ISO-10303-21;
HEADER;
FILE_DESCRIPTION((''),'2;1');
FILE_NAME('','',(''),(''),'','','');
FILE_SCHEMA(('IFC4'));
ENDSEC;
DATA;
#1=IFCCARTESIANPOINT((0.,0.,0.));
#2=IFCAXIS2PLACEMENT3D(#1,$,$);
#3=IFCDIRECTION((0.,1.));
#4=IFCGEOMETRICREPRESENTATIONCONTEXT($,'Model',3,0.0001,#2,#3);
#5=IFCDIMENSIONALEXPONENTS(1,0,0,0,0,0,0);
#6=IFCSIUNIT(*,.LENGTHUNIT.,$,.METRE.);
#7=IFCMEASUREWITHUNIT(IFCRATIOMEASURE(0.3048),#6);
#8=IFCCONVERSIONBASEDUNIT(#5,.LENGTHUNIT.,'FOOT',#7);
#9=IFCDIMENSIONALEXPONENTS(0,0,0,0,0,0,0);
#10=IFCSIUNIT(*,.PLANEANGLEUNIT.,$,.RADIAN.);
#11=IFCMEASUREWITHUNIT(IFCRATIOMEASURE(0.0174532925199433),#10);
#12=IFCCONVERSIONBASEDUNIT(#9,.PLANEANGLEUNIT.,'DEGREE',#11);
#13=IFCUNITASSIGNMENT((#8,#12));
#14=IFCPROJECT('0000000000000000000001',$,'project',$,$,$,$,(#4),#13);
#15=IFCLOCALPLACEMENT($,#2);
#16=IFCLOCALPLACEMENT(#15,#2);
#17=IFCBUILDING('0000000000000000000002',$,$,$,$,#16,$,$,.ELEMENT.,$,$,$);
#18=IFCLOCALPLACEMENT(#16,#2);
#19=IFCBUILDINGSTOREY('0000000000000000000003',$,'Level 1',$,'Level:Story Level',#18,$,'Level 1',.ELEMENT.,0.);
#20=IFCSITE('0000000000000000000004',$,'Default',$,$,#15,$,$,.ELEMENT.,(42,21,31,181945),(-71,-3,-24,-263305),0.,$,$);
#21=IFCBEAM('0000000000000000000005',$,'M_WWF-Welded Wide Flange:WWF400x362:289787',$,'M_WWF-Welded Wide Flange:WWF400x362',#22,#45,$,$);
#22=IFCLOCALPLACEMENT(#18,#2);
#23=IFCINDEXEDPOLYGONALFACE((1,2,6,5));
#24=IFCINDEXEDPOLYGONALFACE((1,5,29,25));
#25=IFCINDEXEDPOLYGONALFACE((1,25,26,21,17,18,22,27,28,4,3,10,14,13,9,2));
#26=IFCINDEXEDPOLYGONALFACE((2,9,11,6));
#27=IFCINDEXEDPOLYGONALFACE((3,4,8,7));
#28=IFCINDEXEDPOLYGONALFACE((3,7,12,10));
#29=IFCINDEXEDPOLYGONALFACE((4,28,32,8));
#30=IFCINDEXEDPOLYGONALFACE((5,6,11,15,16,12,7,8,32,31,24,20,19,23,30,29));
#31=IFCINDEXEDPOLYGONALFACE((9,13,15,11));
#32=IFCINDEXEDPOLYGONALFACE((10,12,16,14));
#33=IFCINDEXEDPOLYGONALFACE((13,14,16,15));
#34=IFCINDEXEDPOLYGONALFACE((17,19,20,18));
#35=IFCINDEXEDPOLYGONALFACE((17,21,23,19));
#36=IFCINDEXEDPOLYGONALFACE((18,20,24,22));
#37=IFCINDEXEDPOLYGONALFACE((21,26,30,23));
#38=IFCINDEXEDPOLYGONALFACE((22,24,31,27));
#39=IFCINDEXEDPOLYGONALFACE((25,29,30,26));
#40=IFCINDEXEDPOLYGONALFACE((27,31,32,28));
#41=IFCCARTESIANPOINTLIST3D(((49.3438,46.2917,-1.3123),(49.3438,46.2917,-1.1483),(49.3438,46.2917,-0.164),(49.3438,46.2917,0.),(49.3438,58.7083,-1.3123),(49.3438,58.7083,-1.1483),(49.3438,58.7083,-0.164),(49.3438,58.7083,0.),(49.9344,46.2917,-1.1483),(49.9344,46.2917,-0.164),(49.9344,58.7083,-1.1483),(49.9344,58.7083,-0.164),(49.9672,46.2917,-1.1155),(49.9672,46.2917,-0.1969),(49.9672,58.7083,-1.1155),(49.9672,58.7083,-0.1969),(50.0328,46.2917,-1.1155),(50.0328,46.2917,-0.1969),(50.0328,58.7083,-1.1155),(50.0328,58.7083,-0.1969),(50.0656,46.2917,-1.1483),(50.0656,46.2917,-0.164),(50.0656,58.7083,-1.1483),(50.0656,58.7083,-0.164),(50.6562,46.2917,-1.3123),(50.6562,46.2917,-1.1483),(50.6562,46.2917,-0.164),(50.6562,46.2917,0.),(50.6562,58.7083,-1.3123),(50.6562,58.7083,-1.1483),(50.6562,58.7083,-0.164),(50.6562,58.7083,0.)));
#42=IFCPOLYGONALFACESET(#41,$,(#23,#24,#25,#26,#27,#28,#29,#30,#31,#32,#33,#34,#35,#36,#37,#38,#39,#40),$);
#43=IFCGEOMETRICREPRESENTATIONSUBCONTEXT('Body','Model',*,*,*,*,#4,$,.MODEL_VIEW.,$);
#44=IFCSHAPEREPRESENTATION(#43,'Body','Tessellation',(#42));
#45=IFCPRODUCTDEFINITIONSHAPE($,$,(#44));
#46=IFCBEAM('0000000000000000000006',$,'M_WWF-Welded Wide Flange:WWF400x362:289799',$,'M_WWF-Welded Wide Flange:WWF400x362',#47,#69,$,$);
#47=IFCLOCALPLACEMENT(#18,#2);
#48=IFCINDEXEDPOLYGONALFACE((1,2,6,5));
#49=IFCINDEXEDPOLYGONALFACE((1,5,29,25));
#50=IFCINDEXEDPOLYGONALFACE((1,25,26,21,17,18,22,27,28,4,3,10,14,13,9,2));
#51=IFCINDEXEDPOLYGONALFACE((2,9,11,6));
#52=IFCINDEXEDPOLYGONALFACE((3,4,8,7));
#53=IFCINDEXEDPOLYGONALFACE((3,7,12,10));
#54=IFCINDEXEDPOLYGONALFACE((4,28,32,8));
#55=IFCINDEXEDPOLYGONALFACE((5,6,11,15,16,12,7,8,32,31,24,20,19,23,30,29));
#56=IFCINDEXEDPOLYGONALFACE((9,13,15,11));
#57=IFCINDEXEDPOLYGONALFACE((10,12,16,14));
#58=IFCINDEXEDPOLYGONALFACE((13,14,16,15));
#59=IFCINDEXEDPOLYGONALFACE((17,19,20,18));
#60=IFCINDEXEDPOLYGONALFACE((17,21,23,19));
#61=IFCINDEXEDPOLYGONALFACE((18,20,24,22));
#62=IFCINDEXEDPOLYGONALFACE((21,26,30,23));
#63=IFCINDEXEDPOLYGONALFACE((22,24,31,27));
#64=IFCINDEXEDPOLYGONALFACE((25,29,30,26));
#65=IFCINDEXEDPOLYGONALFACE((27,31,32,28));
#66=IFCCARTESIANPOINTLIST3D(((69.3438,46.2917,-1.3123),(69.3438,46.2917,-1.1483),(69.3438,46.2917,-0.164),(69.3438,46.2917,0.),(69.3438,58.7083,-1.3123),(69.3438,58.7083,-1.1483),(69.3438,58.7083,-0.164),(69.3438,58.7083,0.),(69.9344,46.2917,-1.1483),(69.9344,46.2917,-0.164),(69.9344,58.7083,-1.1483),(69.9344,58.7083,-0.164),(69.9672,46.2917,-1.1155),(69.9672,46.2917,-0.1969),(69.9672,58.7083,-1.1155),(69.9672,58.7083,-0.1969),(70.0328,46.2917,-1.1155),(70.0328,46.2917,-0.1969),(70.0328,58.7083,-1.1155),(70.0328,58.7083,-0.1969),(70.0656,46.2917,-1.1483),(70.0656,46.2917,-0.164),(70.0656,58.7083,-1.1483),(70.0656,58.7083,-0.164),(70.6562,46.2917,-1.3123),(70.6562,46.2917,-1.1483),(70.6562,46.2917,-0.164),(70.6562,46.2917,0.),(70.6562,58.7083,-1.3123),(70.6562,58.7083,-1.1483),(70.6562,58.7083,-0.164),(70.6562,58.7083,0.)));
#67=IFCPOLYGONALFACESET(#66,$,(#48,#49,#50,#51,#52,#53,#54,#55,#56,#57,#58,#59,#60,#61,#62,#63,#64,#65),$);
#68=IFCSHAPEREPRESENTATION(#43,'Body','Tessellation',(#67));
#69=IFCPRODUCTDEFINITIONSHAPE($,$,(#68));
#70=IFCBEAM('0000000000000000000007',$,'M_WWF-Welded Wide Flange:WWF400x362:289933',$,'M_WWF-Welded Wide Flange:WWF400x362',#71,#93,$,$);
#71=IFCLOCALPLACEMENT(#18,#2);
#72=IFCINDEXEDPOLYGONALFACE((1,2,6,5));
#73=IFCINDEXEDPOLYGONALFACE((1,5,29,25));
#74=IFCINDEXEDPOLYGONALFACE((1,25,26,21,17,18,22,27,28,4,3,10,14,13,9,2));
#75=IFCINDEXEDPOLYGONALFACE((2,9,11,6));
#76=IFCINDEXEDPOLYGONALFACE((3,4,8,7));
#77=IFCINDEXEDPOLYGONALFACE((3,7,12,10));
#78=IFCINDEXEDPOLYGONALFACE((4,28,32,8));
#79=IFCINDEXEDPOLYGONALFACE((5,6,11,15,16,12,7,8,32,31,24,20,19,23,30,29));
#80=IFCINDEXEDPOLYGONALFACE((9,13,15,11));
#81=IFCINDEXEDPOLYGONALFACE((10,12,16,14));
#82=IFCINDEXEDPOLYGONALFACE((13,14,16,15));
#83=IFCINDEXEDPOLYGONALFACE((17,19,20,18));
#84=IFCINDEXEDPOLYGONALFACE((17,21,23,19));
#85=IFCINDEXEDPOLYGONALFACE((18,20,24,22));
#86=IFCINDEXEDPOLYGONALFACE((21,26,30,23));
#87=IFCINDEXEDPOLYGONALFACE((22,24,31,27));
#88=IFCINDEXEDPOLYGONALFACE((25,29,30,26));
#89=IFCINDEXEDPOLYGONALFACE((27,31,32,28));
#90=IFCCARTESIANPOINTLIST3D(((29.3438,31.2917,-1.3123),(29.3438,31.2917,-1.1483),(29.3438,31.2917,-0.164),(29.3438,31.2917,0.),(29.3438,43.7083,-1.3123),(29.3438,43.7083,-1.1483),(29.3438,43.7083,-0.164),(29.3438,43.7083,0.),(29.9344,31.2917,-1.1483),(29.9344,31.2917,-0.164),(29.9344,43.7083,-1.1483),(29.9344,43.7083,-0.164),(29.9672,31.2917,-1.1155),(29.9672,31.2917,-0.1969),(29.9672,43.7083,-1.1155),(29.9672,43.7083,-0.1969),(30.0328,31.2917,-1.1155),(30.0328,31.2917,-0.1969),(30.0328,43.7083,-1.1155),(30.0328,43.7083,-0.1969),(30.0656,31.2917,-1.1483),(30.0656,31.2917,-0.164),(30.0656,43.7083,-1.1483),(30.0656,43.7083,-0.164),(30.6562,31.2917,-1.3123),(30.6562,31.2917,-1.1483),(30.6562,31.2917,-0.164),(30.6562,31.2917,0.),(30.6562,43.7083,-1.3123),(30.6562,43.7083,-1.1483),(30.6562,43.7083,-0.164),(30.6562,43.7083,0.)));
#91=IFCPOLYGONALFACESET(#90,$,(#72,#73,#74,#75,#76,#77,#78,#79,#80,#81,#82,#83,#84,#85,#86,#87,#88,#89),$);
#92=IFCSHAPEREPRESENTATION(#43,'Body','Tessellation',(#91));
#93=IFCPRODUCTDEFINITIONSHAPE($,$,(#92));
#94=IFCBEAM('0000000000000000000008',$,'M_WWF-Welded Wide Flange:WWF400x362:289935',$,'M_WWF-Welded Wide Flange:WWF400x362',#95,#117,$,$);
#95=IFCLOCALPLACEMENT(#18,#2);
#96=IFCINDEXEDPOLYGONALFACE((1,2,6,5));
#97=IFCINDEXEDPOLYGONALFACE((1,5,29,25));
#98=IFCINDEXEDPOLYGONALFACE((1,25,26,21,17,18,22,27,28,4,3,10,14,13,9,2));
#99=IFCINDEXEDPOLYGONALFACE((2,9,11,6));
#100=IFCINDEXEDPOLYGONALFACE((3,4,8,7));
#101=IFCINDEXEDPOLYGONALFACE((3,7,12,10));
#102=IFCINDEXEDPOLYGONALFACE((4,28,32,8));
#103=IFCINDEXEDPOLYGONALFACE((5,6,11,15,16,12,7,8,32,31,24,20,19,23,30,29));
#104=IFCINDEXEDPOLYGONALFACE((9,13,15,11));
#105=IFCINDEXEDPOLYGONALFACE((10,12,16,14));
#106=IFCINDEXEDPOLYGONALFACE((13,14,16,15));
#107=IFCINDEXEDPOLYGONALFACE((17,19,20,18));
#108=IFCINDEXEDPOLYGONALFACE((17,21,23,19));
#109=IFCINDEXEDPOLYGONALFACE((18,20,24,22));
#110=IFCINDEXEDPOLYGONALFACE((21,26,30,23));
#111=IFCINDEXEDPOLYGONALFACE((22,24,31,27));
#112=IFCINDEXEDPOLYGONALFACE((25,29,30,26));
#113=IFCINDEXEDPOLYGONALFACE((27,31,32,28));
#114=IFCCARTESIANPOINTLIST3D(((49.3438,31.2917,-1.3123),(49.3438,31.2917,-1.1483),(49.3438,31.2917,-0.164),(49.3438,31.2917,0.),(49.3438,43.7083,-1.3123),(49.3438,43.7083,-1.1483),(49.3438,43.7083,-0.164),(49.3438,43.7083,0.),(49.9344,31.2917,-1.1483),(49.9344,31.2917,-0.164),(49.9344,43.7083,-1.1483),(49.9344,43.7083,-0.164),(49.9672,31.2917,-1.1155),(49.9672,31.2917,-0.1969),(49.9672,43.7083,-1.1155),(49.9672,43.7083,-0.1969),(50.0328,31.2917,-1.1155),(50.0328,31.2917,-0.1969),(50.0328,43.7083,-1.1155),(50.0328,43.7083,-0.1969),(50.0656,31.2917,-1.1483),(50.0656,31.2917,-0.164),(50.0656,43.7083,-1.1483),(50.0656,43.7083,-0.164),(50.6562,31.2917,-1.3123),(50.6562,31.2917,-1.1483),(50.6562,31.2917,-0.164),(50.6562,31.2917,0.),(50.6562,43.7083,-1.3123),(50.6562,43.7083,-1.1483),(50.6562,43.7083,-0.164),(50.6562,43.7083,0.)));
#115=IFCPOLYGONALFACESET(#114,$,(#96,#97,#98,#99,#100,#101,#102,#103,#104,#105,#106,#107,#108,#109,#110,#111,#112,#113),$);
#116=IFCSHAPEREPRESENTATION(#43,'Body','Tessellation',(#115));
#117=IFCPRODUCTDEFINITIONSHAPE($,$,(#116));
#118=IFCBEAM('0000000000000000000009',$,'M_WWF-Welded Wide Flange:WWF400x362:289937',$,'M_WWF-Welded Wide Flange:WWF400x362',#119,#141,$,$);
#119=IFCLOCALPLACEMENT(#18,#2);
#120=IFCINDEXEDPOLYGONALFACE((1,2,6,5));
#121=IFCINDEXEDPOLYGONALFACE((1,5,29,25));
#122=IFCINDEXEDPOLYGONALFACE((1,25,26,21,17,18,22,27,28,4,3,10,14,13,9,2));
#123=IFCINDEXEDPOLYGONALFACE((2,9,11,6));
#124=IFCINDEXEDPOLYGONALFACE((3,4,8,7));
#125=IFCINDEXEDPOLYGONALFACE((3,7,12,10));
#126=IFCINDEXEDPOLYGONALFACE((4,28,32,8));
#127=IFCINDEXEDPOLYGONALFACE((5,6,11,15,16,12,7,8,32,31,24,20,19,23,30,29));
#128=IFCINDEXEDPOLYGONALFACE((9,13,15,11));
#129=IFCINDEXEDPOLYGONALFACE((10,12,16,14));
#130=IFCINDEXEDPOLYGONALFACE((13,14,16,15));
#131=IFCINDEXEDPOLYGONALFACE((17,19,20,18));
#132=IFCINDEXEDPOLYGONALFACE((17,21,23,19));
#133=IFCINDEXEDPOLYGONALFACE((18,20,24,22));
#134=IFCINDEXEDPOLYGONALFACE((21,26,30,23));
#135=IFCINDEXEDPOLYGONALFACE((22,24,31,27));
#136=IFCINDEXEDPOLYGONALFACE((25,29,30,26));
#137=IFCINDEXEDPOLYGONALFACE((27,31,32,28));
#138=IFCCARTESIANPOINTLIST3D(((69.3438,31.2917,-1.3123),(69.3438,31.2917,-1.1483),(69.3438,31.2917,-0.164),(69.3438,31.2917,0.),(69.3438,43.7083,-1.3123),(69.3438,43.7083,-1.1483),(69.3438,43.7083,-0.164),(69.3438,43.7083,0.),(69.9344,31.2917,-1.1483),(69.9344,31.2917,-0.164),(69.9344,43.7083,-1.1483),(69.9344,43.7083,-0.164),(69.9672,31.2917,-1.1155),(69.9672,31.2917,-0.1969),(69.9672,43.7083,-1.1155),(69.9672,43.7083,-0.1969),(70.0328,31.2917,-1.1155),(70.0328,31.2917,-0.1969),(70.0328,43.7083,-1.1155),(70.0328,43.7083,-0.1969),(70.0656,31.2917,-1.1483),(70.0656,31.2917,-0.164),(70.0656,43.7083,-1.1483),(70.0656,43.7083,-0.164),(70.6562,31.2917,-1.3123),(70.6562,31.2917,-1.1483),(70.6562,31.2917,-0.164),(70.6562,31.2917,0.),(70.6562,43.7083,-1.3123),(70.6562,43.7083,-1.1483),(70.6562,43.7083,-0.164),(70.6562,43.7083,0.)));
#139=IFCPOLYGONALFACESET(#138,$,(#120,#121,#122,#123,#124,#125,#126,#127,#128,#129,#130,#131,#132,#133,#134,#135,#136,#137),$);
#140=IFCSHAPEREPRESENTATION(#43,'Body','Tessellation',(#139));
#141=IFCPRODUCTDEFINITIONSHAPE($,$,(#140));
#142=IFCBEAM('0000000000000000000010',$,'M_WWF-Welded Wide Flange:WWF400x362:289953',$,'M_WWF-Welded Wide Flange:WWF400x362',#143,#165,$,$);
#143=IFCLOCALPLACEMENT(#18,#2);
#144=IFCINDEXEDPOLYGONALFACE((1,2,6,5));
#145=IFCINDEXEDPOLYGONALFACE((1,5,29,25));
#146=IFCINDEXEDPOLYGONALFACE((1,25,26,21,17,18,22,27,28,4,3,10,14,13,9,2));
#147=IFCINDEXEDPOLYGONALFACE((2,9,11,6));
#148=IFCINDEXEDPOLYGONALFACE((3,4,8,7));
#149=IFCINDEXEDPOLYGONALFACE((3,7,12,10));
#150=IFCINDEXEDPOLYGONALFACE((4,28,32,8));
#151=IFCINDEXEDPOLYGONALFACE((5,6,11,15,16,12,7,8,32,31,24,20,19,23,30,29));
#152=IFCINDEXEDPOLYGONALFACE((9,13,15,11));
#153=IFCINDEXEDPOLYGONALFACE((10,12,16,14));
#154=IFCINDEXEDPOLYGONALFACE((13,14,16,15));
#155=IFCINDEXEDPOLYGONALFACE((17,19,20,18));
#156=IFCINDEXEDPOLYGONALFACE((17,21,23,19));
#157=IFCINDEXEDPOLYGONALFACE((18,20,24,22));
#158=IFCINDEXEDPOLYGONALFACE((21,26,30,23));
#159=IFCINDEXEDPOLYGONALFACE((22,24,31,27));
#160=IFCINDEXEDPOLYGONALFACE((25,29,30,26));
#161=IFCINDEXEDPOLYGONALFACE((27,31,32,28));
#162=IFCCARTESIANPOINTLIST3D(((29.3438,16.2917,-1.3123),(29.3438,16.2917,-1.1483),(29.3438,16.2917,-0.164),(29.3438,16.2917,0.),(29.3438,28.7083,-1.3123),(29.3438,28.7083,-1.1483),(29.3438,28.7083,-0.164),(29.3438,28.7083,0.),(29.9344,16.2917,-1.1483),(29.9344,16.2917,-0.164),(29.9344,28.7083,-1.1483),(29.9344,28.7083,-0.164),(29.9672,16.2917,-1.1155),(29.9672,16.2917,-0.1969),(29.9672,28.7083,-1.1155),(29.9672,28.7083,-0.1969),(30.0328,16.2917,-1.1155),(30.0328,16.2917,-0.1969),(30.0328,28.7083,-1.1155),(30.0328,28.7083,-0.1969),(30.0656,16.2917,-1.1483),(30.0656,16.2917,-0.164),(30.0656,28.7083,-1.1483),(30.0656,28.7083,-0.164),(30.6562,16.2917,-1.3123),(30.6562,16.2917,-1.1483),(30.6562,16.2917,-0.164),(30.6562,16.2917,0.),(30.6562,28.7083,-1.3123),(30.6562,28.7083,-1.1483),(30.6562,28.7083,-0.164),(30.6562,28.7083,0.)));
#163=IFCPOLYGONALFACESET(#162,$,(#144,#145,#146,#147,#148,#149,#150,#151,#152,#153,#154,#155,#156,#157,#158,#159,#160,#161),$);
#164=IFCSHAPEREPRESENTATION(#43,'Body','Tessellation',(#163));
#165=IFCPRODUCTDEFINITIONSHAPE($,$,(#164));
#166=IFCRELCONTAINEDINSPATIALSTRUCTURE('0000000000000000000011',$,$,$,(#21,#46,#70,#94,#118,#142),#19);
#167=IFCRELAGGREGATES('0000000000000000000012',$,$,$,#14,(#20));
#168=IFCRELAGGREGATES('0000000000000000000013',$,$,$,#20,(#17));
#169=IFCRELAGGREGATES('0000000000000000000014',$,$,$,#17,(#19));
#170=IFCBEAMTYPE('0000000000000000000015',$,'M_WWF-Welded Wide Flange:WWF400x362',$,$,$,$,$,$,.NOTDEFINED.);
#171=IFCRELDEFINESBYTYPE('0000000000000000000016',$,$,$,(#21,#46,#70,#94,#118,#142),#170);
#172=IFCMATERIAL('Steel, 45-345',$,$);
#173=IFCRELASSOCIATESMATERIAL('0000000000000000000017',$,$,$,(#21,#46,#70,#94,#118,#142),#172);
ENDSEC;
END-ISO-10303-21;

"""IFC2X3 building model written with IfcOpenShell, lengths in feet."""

from ifc_helpers import new_model, entity, si_unit, converted_unit, direction, frame, origin, place, context, subcontext, project, spatial, polyline, outline, extrude, material, type_object, element, save


model = new_model("IFC2X3")

# Units and contexts
model_context = context("Model", 3, precision=0.0001, world=origin(), true_north=direction((0.0, 1.0)))
body_context = subcontext(model_context, "Body", "Model", "MODEL_VIEW")
ifc_project = project(units=[converted_unit("LENGTHUNIT", "FOOT", entity("IfcRatioMeasure", 0.3048), si_unit("LENGTHUNIT", "METRE"), dimensions=[1, 0, 0, 0, 0, 0, 0]), converted_unit("PLANEANGLEUNIT", "DEGREE", entity("IfcRatioMeasure", 0.0174532925199433), si_unit("PLANEANGLEUNIT", "RADIAN"), dimensions=[0, 0, 0, 0, 0, 0, 0])], contexts=[model_context])

# Site, building, storey
site_placement = place(None, origin())
site = spatial("IfcSite", under=ifc_project, at=site_placement, Name="Default", CompositionType="ELEMENT", RefLatitude=(42, 21, 31, 181945), RefLongitude=(-71, -3, -24, -263305), RefElevation=0.0)
building_placement = place(site_placement, origin())
building = spatial("IfcBuilding", under=site, at=building_placement, CompositionType="ELEMENT")
storey_placement = place(building_placement, origin())
storey = spatial("IfcBuildingStorey", under=building, at=storey_placement, Name="Level 1", ObjectType="Level:Story Level", LongName="Level 1", CompositionType="ELEMENT", Elevation=0.0)

# Shared definitions
ifc_material = material(Name="Steel, 45-345")

# Beams
beam_type = type_object("IfcBeamType", Name="M_WWF-Welded Wide Flange:WWF400x362", PredefinedType="NOTDEFINED")
beam_1_placement = place(storey_placement, frame((50.0, 45.0, 0.0), z_axis=(0.0, 0.0, 1.0), x_axis=(0.0, 1.0, 0.0)))
element("IfcBeam", 1, at=beam_1_placement, inside=storey, type_object=beam_type, material=ifc_material, Name="M_WWF-Welded Wide Flange:WWF400x362:289787", ObjectType="M_WWF-Welded Wide Flange:WWF400x362", context=body_context, shape_type="SweptSolid", body=[
    extrude(outline(polyline([(-0.6562, -0.6562), (-0.4921, -0.6562), (-0.4921, -0.0656), (-0.4593, -0.0328), (0.4593, -0.0328), (0.4921, -0.0656), (0.4921, -0.6562), (0.6562, -0.6562), (0.6562, 0.6562), (0.4921, 0.6562), (0.4921, 0.0656), (0.4593, 0.0328), (-0.4593, 0.0328), (-0.4921, 0.0656), (-0.4921, 0.6562), (-0.6562, 0.6562), (-0.6562, -0.6562)])), frame((1.2917, 0.0, -0.6562), z_axis=(1.0, 0.0, 0.0), x_axis=(0.0, 0.0, -1.0)), (0.0, 0.0, 1.0), 12.4167),
])
beam_2_placement = place(storey_placement, frame((70.0, 45.0, 0.0), z_axis=(0.0, 0.0, 1.0), x_axis=(0.0, 1.0, 0.0)))
element("IfcBeam", 2, at=beam_2_placement, inside=storey, type_object=beam_type, material=ifc_material, Name="M_WWF-Welded Wide Flange:WWF400x362:289799", ObjectType="M_WWF-Welded Wide Flange:WWF400x362", context=body_context, shape_type="SweptSolid", body=[
    extrude(outline(polyline([(-0.6562, -0.6562), (-0.4921, -0.6562), (-0.4921, -0.0656), (-0.4593, -0.0328), (0.4593, -0.0328), (0.4921, -0.0656), (0.4921, -0.6562), (0.6562, -0.6562), (0.6562, 0.6562), (0.4921, 0.6562), (0.4921, 0.0656), (0.4593, 0.0328), (-0.4593, 0.0328), (-0.4921, 0.0656), (-0.4921, 0.6562), (-0.6562, 0.6562), (-0.6562, -0.6562)])), frame((1.2917, 0.0, -0.6562), z_axis=(1.0, 0.0, 0.0), x_axis=(0.0, 0.0, -1.0)), (0.0, 0.0, 1.0), 12.4167),
])
beam_3_placement = place(storey_placement, frame((30.0, 30.0, 0.0), z_axis=(0.0, 0.0, 1.0), x_axis=(0.0, 1.0, 0.0)))
element("IfcBeam", 3, at=beam_3_placement, inside=storey, type_object=beam_type, material=ifc_material, Name="M_WWF-Welded Wide Flange:WWF400x362:289933", ObjectType="M_WWF-Welded Wide Flange:WWF400x362", context=body_context, shape_type="SweptSolid", body=[
    extrude(outline(polyline([(-0.6562, -0.6562), (-0.4921, -0.6562), (-0.4921, -0.0656), (-0.4593, -0.0328), (0.4593, -0.0328), (0.4921, -0.0656), (0.4921, -0.6562), (0.6562, -0.6562), (0.6562, 0.6562), (0.4921, 0.6562), (0.4921, 0.0656), (0.4593, 0.0328), (-0.4593, 0.0328), (-0.4921, 0.0656), (-0.4921, 0.6562), (-0.6562, 0.6562), (-0.6562, -0.6562)])), frame((1.2917, 0.0, -0.6562), z_axis=(1.0, 0.0, 0.0), x_axis=(0.0, 0.0, -1.0)), (0.0, 0.0, 1.0), 12.4167),
])
beam_4_placement = place(storey_placement, frame((50.0, 30.0, 0.0), z_axis=(0.0, 0.0, 1.0), x_axis=(0.0, 1.0, 0.0)))
element("IfcBeam", 4, at=beam_4_placement, inside=storey, type_object=beam_type, material=ifc_material, Name="M_WWF-Welded Wide Flange:WWF400x362:289935", ObjectType="M_WWF-Welded Wide Flange:WWF400x362", context=body_context, shape_type="SweptSolid", body=[
    extrude(outline(polyline([(-0.6562, -0.6562), (-0.4921, -0.6562), (-0.4921, -0.0656), (-0.4593, -0.0328), (0.4593, -0.0328), (0.4921, -0.0656), (0.4921, -0.6562), (0.6562, -0.6562), (0.6562, 0.6562), (0.4921, 0.6562), (0.4921, 0.0656), (0.4593, 0.0328), (-0.4593, 0.0328), (-0.4921, 0.0656), (-0.4921, 0.6562), (-0.6562, 0.6562), (-0.6562, -0.6562)])), frame((1.2917, 0.0, -0.6562), z_axis=(1.0, 0.0, 0.0), x_axis=(0.0, 0.0, -1.0)), (0.0, 0.0, 1.0), 12.4167),
])
beam_5_placement = place(storey_placement, frame((70.0, 30.0, 0.0), z_axis=(0.0, 0.0, 1.0), x_axis=(0.0, 1.0, 0.0)))
element("IfcBeam", 5, at=beam_5_placement, inside=storey, type_object=beam_type, material=ifc_material, Name="M_WWF-Welded Wide Flange:WWF400x362:289937", ObjectType="M_WWF-Welded Wide Flange:WWF400x362", context=body_context, shape_type="SweptSolid", body=[
    extrude(outline(polyline([(-0.6562, -0.6562), (-0.4921, -0.6562), (-0.4921, -0.0656), (-0.4593, -0.0328), (0.4593, -0.0328), (0.4921, -0.0656), (0.4921, -0.6562), (0.6562, -0.6562), (0.6562, 0.6562), (0.4921, 0.6562), (0.4921, 0.0656), (0.4593, 0.0328), (-0.4593, 0.0328), (-0.4921, 0.0656), (-0.4921, 0.6562), (-0.6562, 0.6562), (-0.6562, -0.6562)])), frame((1.2917, 0.0, -0.6562), z_axis=(1.0, 0.0, 0.0), x_axis=(0.0, 0.0, -1.0)), (0.0, 0.0, 1.0), 12.4167),
])
beam_6_placement = place(storey_placement, frame((30.0, 15.0, 0.0), z_axis=(0.0, 0.0, 1.0), x_axis=(0.0, 1.0, 0.0)))
element("IfcBeam", 6, at=beam_6_placement, inside=storey, type_object=beam_type, material=ifc_material, Name="M_WWF-Welded Wide Flange:WWF400x362:289953", ObjectType="M_WWF-Welded Wide Flange:WWF400x362", context=body_context, shape_type="SweptSolid", body=[
    extrude(outline(polyline([(-0.6562, -0.6562), (-0.4921, -0.6562), (-0.4921, -0.0656), (-0.4593, -0.0328), (0.4593, -0.0328), (0.4921, -0.0656), (0.4921, -0.6562), (0.6562, -0.6562), (0.6562, 0.6562), (0.4921, 0.6562), (0.4921, 0.0656), (0.4593, 0.0328), (-0.4593, 0.0328), (-0.4921, 0.0656), (-0.4921, 0.6562), (-0.6562, 0.6562), (-0.6562, -0.6562)])), frame((1.2917, 0.0, -0.6562), z_axis=(1.0, 0.0, 0.0), x_axis=(0.0, 0.0, -1.0)), (0.0, 0.0, 1.0), 12.4167),
])

save(model, "model.ifc")
